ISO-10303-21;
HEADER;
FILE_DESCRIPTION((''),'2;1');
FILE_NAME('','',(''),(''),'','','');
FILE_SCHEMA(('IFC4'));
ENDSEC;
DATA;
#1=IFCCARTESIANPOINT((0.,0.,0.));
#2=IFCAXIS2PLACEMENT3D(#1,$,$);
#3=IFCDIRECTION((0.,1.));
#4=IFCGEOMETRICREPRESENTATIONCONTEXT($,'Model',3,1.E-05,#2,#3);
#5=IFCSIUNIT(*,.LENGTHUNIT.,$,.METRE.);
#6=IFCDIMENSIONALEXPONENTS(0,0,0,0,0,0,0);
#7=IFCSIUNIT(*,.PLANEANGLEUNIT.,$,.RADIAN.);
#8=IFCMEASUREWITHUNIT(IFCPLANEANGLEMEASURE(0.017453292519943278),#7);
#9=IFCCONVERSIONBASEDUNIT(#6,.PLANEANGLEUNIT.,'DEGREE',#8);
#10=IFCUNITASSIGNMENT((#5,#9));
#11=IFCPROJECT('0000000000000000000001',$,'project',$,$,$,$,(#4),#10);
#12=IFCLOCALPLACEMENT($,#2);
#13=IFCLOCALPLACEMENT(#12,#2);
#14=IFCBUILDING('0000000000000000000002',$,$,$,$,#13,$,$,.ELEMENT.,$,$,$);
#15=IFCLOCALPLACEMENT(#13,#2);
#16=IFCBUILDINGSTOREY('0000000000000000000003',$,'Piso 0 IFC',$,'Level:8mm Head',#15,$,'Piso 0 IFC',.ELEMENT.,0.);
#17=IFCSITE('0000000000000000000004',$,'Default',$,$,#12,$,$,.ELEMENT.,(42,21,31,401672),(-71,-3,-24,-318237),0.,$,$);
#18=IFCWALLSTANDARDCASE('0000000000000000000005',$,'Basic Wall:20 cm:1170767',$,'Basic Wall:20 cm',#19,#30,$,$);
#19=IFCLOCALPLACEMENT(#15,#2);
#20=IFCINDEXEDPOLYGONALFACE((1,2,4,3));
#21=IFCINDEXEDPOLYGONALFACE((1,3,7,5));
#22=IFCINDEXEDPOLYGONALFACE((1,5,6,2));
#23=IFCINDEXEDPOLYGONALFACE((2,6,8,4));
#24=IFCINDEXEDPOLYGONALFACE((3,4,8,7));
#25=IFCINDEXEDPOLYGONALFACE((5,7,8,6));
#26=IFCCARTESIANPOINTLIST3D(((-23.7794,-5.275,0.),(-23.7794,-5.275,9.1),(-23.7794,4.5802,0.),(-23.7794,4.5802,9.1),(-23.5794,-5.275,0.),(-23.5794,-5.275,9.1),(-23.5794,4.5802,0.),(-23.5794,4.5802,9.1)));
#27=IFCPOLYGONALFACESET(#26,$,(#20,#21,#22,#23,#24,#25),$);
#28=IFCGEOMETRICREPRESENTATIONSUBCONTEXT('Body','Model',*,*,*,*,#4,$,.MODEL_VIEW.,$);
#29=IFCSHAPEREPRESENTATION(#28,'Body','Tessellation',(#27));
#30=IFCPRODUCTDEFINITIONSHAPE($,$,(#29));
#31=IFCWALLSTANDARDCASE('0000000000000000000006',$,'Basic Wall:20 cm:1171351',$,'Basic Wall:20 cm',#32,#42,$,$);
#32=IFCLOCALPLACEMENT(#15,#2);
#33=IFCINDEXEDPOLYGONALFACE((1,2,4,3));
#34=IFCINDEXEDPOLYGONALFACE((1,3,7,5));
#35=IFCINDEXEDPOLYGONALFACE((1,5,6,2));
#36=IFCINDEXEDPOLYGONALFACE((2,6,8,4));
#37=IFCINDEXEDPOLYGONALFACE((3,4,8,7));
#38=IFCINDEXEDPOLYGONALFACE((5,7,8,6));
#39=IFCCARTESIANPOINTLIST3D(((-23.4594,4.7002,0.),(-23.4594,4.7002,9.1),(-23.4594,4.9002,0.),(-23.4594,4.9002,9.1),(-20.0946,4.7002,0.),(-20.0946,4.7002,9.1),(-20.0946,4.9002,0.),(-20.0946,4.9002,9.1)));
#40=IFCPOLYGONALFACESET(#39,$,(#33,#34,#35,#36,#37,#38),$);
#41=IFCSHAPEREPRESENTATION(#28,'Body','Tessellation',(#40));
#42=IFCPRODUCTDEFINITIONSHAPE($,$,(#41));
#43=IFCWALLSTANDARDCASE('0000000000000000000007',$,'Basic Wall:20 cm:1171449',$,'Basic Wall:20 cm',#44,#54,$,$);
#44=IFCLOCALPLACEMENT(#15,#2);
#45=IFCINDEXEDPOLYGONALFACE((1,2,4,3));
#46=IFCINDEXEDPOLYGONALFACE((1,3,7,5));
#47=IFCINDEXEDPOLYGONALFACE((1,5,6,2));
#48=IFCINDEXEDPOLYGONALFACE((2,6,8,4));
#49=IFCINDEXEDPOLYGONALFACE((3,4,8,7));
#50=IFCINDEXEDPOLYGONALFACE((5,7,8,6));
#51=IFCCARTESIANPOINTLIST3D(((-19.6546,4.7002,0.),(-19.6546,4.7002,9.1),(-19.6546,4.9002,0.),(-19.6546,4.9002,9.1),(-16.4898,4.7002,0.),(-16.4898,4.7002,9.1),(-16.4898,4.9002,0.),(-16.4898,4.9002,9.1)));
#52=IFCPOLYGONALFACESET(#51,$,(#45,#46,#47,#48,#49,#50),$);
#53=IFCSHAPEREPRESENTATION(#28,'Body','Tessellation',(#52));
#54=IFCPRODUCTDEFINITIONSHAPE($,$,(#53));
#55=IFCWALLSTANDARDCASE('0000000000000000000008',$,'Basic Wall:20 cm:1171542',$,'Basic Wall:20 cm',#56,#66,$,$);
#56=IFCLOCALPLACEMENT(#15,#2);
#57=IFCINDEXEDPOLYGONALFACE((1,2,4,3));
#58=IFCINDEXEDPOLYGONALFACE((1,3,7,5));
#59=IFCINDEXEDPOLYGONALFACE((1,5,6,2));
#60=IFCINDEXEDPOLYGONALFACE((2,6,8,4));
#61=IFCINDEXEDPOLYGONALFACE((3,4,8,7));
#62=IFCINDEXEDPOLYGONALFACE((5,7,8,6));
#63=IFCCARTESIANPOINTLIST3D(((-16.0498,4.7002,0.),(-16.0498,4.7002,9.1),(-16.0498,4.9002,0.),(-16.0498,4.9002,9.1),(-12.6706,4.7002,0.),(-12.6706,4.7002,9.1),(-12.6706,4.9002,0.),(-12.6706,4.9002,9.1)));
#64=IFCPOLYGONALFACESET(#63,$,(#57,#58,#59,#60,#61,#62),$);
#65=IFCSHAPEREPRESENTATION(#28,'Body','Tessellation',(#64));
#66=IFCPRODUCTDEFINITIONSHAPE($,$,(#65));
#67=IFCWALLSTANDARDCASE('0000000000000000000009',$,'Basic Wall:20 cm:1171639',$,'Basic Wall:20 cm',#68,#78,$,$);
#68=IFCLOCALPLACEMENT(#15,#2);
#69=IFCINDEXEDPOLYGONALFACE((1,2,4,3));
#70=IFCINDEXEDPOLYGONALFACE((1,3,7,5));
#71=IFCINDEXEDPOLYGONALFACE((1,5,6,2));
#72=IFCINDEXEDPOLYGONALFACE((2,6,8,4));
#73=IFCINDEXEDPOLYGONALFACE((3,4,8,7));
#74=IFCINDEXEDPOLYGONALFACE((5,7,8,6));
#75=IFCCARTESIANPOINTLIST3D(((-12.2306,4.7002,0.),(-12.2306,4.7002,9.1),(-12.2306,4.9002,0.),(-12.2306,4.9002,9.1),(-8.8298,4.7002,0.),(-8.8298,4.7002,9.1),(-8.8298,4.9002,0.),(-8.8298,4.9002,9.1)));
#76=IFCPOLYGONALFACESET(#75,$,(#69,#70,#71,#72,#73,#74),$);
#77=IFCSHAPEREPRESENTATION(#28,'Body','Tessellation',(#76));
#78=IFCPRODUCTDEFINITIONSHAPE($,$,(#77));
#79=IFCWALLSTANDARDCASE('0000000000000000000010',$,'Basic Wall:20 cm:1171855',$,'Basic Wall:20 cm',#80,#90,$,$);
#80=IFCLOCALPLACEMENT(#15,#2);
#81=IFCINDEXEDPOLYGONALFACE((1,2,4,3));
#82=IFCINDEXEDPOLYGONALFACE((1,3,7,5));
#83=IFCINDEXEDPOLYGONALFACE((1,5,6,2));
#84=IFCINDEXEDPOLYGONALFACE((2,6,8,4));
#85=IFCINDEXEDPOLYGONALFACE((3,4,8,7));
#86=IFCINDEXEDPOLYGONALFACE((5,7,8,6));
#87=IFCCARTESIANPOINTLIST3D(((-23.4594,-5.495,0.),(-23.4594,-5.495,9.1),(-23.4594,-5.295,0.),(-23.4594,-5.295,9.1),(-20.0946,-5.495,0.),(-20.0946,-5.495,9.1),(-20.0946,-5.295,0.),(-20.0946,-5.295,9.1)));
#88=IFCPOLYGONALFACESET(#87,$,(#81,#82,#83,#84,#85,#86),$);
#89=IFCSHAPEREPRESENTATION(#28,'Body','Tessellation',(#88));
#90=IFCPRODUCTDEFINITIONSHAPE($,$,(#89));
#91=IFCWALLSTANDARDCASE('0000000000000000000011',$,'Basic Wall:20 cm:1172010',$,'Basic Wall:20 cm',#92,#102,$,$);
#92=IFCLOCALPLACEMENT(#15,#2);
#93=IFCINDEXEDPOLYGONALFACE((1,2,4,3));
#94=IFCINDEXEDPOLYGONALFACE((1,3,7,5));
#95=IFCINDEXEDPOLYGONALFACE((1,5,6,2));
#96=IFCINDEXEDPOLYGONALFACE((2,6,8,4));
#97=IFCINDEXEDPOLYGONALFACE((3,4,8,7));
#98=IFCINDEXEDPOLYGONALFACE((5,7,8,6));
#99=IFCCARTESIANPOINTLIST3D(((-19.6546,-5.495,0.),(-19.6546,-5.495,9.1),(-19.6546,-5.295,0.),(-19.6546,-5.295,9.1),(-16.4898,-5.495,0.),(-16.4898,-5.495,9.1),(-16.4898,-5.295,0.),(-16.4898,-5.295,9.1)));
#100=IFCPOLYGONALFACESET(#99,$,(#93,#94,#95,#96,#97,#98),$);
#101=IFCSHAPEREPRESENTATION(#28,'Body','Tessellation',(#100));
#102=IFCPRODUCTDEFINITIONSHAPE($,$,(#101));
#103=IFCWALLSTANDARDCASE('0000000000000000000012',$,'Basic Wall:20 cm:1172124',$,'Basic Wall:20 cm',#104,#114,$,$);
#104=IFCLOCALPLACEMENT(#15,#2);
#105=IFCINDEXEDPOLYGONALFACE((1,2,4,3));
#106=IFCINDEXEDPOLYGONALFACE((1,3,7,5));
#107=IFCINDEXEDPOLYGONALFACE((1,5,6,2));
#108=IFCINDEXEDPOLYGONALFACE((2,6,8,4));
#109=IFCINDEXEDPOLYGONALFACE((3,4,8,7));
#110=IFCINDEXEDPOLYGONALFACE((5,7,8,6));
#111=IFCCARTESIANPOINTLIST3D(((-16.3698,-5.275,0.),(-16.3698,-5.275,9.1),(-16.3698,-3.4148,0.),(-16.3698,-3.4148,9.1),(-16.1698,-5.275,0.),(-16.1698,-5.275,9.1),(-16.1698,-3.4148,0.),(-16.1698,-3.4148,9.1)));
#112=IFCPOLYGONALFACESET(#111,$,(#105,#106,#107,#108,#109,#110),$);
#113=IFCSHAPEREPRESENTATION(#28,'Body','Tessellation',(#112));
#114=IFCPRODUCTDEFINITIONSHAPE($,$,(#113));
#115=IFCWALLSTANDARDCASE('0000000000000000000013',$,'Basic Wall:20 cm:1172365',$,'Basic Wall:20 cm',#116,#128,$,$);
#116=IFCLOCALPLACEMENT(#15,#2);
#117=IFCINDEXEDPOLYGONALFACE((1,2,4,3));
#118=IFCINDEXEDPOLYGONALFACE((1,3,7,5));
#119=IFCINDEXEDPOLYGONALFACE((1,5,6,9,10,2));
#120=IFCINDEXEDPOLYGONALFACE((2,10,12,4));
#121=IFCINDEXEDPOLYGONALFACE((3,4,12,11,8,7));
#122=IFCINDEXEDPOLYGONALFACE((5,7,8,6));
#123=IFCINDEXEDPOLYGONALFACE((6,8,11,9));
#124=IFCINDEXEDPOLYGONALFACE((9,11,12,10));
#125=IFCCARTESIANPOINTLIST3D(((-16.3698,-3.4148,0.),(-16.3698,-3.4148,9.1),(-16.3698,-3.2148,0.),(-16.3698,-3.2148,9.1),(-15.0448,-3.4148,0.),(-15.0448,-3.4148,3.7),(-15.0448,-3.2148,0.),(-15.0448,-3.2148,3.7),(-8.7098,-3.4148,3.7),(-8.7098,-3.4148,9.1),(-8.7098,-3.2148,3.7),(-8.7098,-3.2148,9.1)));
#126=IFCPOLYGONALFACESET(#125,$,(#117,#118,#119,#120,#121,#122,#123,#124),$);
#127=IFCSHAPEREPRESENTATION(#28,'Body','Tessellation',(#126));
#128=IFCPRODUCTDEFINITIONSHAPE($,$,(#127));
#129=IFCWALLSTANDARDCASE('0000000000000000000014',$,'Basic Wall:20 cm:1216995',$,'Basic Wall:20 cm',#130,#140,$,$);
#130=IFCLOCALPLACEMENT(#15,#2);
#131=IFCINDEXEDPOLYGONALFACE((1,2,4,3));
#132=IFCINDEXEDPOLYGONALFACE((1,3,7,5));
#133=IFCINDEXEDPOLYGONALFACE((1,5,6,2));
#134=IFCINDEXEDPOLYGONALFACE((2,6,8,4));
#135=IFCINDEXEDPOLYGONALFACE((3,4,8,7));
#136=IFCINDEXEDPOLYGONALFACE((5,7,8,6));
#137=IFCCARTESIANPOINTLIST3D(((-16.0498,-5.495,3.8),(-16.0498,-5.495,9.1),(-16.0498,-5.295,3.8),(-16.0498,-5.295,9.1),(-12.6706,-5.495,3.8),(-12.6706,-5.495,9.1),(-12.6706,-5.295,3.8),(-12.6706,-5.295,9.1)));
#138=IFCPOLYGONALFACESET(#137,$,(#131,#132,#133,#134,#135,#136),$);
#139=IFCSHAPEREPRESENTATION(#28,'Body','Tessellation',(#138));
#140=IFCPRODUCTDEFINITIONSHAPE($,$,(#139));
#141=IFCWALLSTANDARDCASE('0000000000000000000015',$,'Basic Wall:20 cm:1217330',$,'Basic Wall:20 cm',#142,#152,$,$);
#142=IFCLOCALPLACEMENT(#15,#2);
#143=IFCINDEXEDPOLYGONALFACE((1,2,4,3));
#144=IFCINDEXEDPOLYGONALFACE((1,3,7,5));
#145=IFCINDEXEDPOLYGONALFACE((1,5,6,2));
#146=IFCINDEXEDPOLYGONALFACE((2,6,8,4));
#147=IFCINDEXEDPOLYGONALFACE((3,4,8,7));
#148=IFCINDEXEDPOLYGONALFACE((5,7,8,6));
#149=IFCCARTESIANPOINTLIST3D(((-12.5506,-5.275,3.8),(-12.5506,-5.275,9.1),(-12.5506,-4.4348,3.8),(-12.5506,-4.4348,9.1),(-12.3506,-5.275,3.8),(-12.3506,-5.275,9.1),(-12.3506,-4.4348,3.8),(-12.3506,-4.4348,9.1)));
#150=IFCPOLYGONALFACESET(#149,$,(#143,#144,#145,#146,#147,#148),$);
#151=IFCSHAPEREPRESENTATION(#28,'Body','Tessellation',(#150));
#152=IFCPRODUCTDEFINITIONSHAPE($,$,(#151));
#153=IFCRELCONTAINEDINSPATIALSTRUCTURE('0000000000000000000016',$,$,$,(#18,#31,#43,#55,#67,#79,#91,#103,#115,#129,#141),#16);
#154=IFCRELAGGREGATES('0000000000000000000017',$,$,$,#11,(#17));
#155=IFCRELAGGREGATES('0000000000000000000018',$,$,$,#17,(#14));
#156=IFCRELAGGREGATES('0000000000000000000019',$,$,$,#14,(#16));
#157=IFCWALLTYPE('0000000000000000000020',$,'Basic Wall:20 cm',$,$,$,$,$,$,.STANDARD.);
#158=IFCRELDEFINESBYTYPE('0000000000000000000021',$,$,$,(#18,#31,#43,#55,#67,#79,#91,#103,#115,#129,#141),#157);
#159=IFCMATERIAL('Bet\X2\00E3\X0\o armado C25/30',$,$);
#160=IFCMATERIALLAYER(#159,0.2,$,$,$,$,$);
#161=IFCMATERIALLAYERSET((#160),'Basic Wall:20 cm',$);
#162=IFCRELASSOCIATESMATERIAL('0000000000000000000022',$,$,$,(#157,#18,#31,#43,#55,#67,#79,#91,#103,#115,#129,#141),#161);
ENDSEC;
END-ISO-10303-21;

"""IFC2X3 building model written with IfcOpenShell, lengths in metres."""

from ifc_helpers import new_model, entity, si_unit, converted_unit, direction, frame, frame_2d, origin, origin_2d_with_axis, place, context, subcontext, project, spatial, polyline, rectangle, extrude, clip, bounded_halfspace, material, layer, layer_set, layer_usage, type_object, element, save


model = new_model("IFC2X3")

# Units and contexts
model_context = context("Model", 3, precision=1e-05, world=origin(), true_north=direction((0.0, 1.0)))
body_context = subcontext(model_context, "Body", "Model", "MODEL_VIEW")
ifc_project = project(units=[si_unit("LENGTHUNIT", "METRE"), converted_unit("PLANEANGLEUNIT", "DEGREE", entity("IfcPlaneAngleMeasure", 0.017453292519943278), si_unit("PLANEANGLEUNIT", "RADIAN"), dimensions=[0, 0, 0, 0, 0, 0, 0])], contexts=[model_context])

# Site, building, storey
site_placement = place(None, origin())
site = spatial("IfcSite", under=ifc_project, at=site_placement, Name="Default", CompositionType="ELEMENT", RefLatitude=(42, 21, 31, 401672), RefLongitude=(-71, -3, -24, -318237), RefElevation=0.0)
building_placement = place(site_placement, origin())
building = spatial("IfcBuilding", under=site, at=building_placement, CompositionType="ELEMENT")
storey_placement = place(building_placement, origin())
storey = spatial("IfcBuildingStorey", under=building, at=storey_placement, Name="Piso 0 IFC", ObjectType="Level:8mm Head", LongName="Piso 0 IFC", CompositionType="ELEMENT", Elevation=0.0)

# Walls
ifc_material_1 = material(Name="Betão armado C25/30")
ifc_layer_1 = layer(ifc_material_1, 0.2)
ifc_layer_set_1 = layer_set([ifc_layer_1], Name="Basic Wall:20 cm")
ifc_layer_usage_1 = layer_usage(ifc_layer_set_1, "AXIS2", "NEGATIVE", 0.1)
wall_type_1 = type_object("IfcWallType", Name="Basic Wall:20 cm", PredefinedType="STANDARD", material=ifc_layer_set_1)
wall_1_placement = place(storey_placement, frame((-23.6794, -5.275, 0.0), z_axis=(0.0, 0.0, 1.0), x_axis=(0.0, 1.0, 0.0)))
element("IfcWallStandardCase", 1, at=wall_1_placement, inside=storey, type_object=wall_type_1, material=ifc_layer_usage_1, Name="Basic Wall:20 cm:1170767", ObjectType="Basic Wall:20 cm", context=body_context, shape_type="Clipping", body=[
    clip(extrude(rectangle(XDim=9.8552, YDim=0.2, at=frame_2d((4.9276, 0.0), x_axis=(-1.0, 0.0))), origin(), (0.0, 0.0, 1.0), 9.1), bounded_halfspace(frame((0.0, -0.1, 9.1), z_axis=(0.0, 0.0, -1.0), x_axis=(0.0, 1.0, 0.0)), True, frame((0.0, -0.1, 9.1)), polyline([(0.0, 0.0), (9.8552, 0.0), (9.8552, 0.2), (0.0, 0.2), (0.0, 0.0)]))),
])
ifc_layer_usage_2 = layer_usage(ifc_layer_set_1, "AXIS2", "NEGATIVE", 0.1)
wall_2_placement = place(storey_placement, frame((-23.4594, 4.8002, 0.0)))
element("IfcWallStandardCase", 2, at=wall_2_placement, inside=storey, type_object=wall_type_1, material=ifc_layer_usage_2, Name="Basic Wall:20 cm:1171351", ObjectType="Basic Wall:20 cm", context=body_context, shape_type="Clipping", body=[
    clip(extrude(rectangle(XDim=3.3648, YDim=0.2, at=frame_2d((1.6824, 0.0), x_axis=(-1.0, 0.0))), origin(), (0.0, 0.0, 1.0), 9.1), bounded_halfspace(frame((0.0, -0.1, 9.1), z_axis=(0.0, 0.0, -1.0), x_axis=(-1.0, 0.0, 0.0)), True, frame((0.0, -0.1, 9.1)), polyline([(0.0, 0.0), (3.3648, 0.0), (3.3648, 0.2), (0.0, 0.2), (0.0, 0.0)]))),
])
ifc_layer_usage_3 = layer_usage(ifc_layer_set_1, "AXIS2", "NEGATIVE", 0.1)
wall_3_placement = place(storey_placement, frame((-19.6546, 4.8002, 0.0)))
element("IfcWallStandardCase", 3, at=wall_3_placement, inside=storey, type_object=wall_type_1, material=ifc_layer_usage_3, Name="Basic Wall:20 cm:1171449", ObjectType="Basic Wall:20 cm", context=body_context, shape_type="Clipping", body=[
    clip(extrude(rectangle(XDim=3.1648, YDim=0.2, at=frame_2d((1.5824, 0.0), x_axis=(-1.0, 0.0))), origin(), (0.0, 0.0, 1.0), 9.1), bounded_halfspace(frame((0.0, -0.1, 9.1), z_axis=(0.0, 0.0, -1.0), x_axis=(-1.0, 0.0, 0.0)), True, frame((0.0, -0.1, 9.1)), polyline([(0.0, 0.0), (3.1648, 0.0), (3.1648, 0.2), (0.0, 0.2), (0.0, 0.0)]))),
])
ifc_layer_usage_4 = layer_usage(ifc_layer_set_1, "AXIS2", "NEGATIVE", 0.1)
wall_4_placement = place(storey_placement, frame((-16.0498, 4.8002, 0.0)))
element("IfcWallStandardCase", 4, at=wall_4_placement, inside=storey, type_object=wall_type_1, material=ifc_layer_usage_4, Name="Basic Wall:20 cm:1171542", ObjectType="Basic Wall:20 cm", context=body_context, shape_type="Clipping", body=[
    clip(extrude(rectangle(XDim=3.3792, YDim=0.2, at=frame_2d((1.6896, 0.0), x_axis=(-1.0, 0.0))), origin(), (0.0, 0.0, 1.0), 9.1), bounded_halfspace(frame((0.0, -0.1, 9.1), z_axis=(0.0, 0.0, -1.0), x_axis=(-1.0, 0.0, 0.0)), True, frame((0.0, -0.1, 9.1)), polyline([(0.0, 0.0), (3.3792, 0.0), (3.3792, 0.2), (0.0, 0.2), (0.0, 0.0)]))),
])
ifc_layer_usage_5 = layer_usage(ifc_layer_set_1, "AXIS2", "NEGATIVE", 0.1)
wall_5_placement = place(storey_placement, frame((-12.2306, 4.8002, 0.0)))
element("IfcWallStandardCase", 5, at=wall_5_placement, inside=storey, type_object=wall_type_1, material=ifc_layer_usage_5, Name="Basic Wall:20 cm:1171639", ObjectType="Basic Wall:20 cm", context=body_context, shape_type="Clipping", body=[
    clip(extrude(rectangle(XDim=3.4008, YDim=0.2, at=frame_2d((1.7004, 0.0), x_axis=(-1.0, 0.0))), origin(), (0.0, 0.0, 1.0), 9.1), bounded_halfspace(frame((0.0, -0.1, 9.1), z_axis=(0.0, 0.0, -1.0), x_axis=(-1.0, 0.0, 0.0)), True, frame((0.0, -0.1, 9.1)), polyline([(0.0, 0.0), (3.4008, 0.0), (3.4008, 0.2), (0.0, 0.2), (0.0, 0.0)]))),
])
ifc_layer_usage_6 = layer_usage(ifc_layer_set_1, "AXIS2", "NEGATIVE", 0.1)
wall_6_placement = place(storey_placement, frame((-23.4594, -5.395, 0.0)))
element("IfcWallStandardCase", 6, at=wall_6_placement, inside=storey, type_object=wall_type_1, material=ifc_layer_usage_6, Name="Basic Wall:20 cm:1171855", ObjectType="Basic Wall:20 cm", context=body_context, shape_type="Clipping", body=[
    clip(extrude(rectangle(XDim=3.3648, YDim=0.2, at=frame_2d((1.6824, 0.0), x_axis=(-1.0, 0.0))), origin(), (0.0, 0.0, 1.0), 9.1), bounded_halfspace(frame((0.0, -0.1, 9.1), z_axis=(0.0, 0.0, -1.0), x_axis=(-1.0, 0.0, 0.0)), True, frame((0.0, -0.1, 9.1)), polyline([(0.0, 0.0), (3.3648, 0.0), (3.3648, 0.2), (0.0, 0.2), (0.0, 0.0)]))),
])
ifc_layer_usage_7 = layer_usage(ifc_layer_set_1, "AXIS2", "NEGATIVE", 0.1)
wall_7_placement = place(storey_placement, frame((-19.6546, -5.395, 0.0)))
element("IfcWallStandardCase", 7, at=wall_7_placement, inside=storey, type_object=wall_type_1, material=ifc_layer_usage_7, Name="Basic Wall:20 cm:1172010", ObjectType="Basic Wall:20 cm", context=body_context, shape_type="Clipping", body=[
    clip(extrude(rectangle(XDim=3.1648, YDim=0.2, at=frame_2d((1.5824, 0.0), x_axis=(-1.0, 0.0))), origin(), (0.0, 0.0, 1.0), 9.1), bounded_halfspace(frame((0.0, -0.1, 9.1), z_axis=(0.0, 0.0, -1.0), x_axis=(-1.0, 0.0, 0.0)), True, frame((0.0, -0.1, 9.1)), polyline([(0.0, 0.0), (3.1648, 0.0), (3.1648, 0.2), (0.0, 0.2), (0.0, 0.0)]))),
])
ifc_layer_usage_8 = layer_usage(ifc_layer_set_1, "AXIS2", "NEGATIVE", 0.1)
wall_8_placement = place(storey_placement, frame((-16.2698, -5.275, 0.0), z_axis=(0.0, 0.0, 1.0), x_axis=(0.0, 1.0, 0.0)))
element("IfcWallStandardCase", 8, at=wall_8_placement, inside=storey, type_object=wall_type_1, material=ifc_layer_usage_8, Name="Basic Wall:20 cm:1172124", ObjectType="Basic Wall:20 cm", context=body_context, shape_type="Clipping", body=[
    clip(extrude(rectangle(XDim=1.8602, YDim=0.2, at=frame_2d((0.9301, 0.0), x_axis=(-1.0, 0.0))), origin(), (0.0, 0.0, 1.0), 9.1), bounded_halfspace(frame((0.0, -0.1, 9.1), z_axis=(0.0, 0.0, -1.0), x_axis=(0.0, 1.0, 0.0)), True, frame((0.0, -0.1, 9.1)), polyline([(0.0, 0.0), (1.8602, 0.0), (1.8602, 0.2), (0.0, 0.2), (0.0, 0.0)]))),
])

# Wall, opening
ifc_layer_usage_9 = layer_usage(ifc_layer_set_1, "AXIS2", "NEGATIVE", 0.1)
wall_9_placement = place(storey_placement, frame((-8.7098, -3.3148, 0.0), z_axis=(0.0, 0.0, 1.0), x_axis=(-1.0, 0.0, 0.0)))
wall_9 = element("IfcWallStandardCase", 9, at=wall_9_placement, inside=storey, type_object=wall_type_1, material=ifc_layer_usage_9, Name="Basic Wall:20 cm:1172365", ObjectType="Basic Wall:20 cm", context=body_context, shape_type="Clipping", body=[
    clip(extrude(rectangle(XDim=7.66, YDim=0.2, at=frame_2d((3.83, 0.0), x_axis=(-1.0, 0.0))), origin(), (0.0, 0.0, 1.0), 9.1), bounded_halfspace(frame((0.0, -0.1, 9.1), z_axis=(0.0, 0.0, -1.0), x_axis=(1.0, 0.0, 0.0)), True, frame((0.0, -0.1, 9.1)), polyline([(0.0, 0.0), (7.66, 0.0), (7.66, 0.2), (7.46, 0.2), (0.0, 0.2), (0.0, 0.0)]))),
])
opening_1_placement = place(wall_9_placement, origin())
element("IfcOpeningElement", 10, at=opening_1_placement, cuts=wall_9, ObjectType="Opening", context=body_context, shape_type="SweptSolid", body=[
    extrude(rectangle(XDim=3.7, YDim=6.435, at=origin_2d_with_axis()), frame((3.1175, 0.1, 1.85), z_axis=(0.0, -1.0, 0.0), x_axis=(0.0, 0.0, 1.0)), (0.0, 0.0, 1.0), 0.2),
])

# Walls
ifc_layer_usage_10 = layer_usage(ifc_layer_set_1, "AXIS2", "NEGATIVE", 0.1)
wall_10_placement = place(storey_placement, frame((-16.0498, -5.395, 3.8)))
element("IfcWallStandardCase", 11, at=wall_10_placement, inside=storey, type_object=wall_type_1, material=ifc_layer_usage_10, Name="Basic Wall:20 cm:1216995", ObjectType="Basic Wall:20 cm", context=body_context, shape_type="Clipping", body=[
    clip(extrude(rectangle(XDim=3.3792, YDim=0.2, at=frame_2d((1.6896, 0.0), x_axis=(-1.0, 0.0))), origin(), (0.0, 0.0, 1.0), 5.3), bounded_halfspace(frame((0.0, -0.1, 5.3), z_axis=(0.0, 0.0, -1.0), x_axis=(-1.0, 0.0, 0.0)), True, frame((0.0, -0.1, 5.3)), polyline([(0.0, 0.0), (3.3792, 0.0), (3.3792, 0.2), (0.0, 0.2), (0.0, 0.0)]))),
])
ifc_layer_usage_11 = layer_usage(ifc_layer_set_1, "AXIS2", "NEGATIVE", 0.1)
wall_11_placement = place(storey_placement, frame((-12.4506, -5.275, 3.8), z_axis=(0.0, 0.0, 1.0), x_axis=(0.0, 1.0, 0.0)))
element("IfcWallStandardCase", 12, at=wall_11_placement, inside=storey, type_object=wall_type_1, material=ifc_layer_usage_11, Name="Basic Wall:20 cm:1217330", ObjectType="Basic Wall:20 cm", context=body_context, shape_type="Clipping", body=[
    clip(extrude(rectangle(XDim=0.8402, YDim=0.2, at=frame_2d((0.4201, 0.0), x_axis=(-1.0, 0.0))), origin(), (0.0, 0.0, 1.0), 5.3), bounded_halfspace(frame((0.0, -0.1, 5.3), z_axis=(0.0, 0.0, -1.0), x_axis=(0.0, 1.0, 0.0)), True, frame((0.0, -0.1, 5.3)), polyline([(0.0, 0.0), (0.6402, 0.0), (0.8402, 0.0), (0.8402, 0.2), (0.0, 0.2), (0.0, 0.0)]))),
])

save(model, "model.ifc")
